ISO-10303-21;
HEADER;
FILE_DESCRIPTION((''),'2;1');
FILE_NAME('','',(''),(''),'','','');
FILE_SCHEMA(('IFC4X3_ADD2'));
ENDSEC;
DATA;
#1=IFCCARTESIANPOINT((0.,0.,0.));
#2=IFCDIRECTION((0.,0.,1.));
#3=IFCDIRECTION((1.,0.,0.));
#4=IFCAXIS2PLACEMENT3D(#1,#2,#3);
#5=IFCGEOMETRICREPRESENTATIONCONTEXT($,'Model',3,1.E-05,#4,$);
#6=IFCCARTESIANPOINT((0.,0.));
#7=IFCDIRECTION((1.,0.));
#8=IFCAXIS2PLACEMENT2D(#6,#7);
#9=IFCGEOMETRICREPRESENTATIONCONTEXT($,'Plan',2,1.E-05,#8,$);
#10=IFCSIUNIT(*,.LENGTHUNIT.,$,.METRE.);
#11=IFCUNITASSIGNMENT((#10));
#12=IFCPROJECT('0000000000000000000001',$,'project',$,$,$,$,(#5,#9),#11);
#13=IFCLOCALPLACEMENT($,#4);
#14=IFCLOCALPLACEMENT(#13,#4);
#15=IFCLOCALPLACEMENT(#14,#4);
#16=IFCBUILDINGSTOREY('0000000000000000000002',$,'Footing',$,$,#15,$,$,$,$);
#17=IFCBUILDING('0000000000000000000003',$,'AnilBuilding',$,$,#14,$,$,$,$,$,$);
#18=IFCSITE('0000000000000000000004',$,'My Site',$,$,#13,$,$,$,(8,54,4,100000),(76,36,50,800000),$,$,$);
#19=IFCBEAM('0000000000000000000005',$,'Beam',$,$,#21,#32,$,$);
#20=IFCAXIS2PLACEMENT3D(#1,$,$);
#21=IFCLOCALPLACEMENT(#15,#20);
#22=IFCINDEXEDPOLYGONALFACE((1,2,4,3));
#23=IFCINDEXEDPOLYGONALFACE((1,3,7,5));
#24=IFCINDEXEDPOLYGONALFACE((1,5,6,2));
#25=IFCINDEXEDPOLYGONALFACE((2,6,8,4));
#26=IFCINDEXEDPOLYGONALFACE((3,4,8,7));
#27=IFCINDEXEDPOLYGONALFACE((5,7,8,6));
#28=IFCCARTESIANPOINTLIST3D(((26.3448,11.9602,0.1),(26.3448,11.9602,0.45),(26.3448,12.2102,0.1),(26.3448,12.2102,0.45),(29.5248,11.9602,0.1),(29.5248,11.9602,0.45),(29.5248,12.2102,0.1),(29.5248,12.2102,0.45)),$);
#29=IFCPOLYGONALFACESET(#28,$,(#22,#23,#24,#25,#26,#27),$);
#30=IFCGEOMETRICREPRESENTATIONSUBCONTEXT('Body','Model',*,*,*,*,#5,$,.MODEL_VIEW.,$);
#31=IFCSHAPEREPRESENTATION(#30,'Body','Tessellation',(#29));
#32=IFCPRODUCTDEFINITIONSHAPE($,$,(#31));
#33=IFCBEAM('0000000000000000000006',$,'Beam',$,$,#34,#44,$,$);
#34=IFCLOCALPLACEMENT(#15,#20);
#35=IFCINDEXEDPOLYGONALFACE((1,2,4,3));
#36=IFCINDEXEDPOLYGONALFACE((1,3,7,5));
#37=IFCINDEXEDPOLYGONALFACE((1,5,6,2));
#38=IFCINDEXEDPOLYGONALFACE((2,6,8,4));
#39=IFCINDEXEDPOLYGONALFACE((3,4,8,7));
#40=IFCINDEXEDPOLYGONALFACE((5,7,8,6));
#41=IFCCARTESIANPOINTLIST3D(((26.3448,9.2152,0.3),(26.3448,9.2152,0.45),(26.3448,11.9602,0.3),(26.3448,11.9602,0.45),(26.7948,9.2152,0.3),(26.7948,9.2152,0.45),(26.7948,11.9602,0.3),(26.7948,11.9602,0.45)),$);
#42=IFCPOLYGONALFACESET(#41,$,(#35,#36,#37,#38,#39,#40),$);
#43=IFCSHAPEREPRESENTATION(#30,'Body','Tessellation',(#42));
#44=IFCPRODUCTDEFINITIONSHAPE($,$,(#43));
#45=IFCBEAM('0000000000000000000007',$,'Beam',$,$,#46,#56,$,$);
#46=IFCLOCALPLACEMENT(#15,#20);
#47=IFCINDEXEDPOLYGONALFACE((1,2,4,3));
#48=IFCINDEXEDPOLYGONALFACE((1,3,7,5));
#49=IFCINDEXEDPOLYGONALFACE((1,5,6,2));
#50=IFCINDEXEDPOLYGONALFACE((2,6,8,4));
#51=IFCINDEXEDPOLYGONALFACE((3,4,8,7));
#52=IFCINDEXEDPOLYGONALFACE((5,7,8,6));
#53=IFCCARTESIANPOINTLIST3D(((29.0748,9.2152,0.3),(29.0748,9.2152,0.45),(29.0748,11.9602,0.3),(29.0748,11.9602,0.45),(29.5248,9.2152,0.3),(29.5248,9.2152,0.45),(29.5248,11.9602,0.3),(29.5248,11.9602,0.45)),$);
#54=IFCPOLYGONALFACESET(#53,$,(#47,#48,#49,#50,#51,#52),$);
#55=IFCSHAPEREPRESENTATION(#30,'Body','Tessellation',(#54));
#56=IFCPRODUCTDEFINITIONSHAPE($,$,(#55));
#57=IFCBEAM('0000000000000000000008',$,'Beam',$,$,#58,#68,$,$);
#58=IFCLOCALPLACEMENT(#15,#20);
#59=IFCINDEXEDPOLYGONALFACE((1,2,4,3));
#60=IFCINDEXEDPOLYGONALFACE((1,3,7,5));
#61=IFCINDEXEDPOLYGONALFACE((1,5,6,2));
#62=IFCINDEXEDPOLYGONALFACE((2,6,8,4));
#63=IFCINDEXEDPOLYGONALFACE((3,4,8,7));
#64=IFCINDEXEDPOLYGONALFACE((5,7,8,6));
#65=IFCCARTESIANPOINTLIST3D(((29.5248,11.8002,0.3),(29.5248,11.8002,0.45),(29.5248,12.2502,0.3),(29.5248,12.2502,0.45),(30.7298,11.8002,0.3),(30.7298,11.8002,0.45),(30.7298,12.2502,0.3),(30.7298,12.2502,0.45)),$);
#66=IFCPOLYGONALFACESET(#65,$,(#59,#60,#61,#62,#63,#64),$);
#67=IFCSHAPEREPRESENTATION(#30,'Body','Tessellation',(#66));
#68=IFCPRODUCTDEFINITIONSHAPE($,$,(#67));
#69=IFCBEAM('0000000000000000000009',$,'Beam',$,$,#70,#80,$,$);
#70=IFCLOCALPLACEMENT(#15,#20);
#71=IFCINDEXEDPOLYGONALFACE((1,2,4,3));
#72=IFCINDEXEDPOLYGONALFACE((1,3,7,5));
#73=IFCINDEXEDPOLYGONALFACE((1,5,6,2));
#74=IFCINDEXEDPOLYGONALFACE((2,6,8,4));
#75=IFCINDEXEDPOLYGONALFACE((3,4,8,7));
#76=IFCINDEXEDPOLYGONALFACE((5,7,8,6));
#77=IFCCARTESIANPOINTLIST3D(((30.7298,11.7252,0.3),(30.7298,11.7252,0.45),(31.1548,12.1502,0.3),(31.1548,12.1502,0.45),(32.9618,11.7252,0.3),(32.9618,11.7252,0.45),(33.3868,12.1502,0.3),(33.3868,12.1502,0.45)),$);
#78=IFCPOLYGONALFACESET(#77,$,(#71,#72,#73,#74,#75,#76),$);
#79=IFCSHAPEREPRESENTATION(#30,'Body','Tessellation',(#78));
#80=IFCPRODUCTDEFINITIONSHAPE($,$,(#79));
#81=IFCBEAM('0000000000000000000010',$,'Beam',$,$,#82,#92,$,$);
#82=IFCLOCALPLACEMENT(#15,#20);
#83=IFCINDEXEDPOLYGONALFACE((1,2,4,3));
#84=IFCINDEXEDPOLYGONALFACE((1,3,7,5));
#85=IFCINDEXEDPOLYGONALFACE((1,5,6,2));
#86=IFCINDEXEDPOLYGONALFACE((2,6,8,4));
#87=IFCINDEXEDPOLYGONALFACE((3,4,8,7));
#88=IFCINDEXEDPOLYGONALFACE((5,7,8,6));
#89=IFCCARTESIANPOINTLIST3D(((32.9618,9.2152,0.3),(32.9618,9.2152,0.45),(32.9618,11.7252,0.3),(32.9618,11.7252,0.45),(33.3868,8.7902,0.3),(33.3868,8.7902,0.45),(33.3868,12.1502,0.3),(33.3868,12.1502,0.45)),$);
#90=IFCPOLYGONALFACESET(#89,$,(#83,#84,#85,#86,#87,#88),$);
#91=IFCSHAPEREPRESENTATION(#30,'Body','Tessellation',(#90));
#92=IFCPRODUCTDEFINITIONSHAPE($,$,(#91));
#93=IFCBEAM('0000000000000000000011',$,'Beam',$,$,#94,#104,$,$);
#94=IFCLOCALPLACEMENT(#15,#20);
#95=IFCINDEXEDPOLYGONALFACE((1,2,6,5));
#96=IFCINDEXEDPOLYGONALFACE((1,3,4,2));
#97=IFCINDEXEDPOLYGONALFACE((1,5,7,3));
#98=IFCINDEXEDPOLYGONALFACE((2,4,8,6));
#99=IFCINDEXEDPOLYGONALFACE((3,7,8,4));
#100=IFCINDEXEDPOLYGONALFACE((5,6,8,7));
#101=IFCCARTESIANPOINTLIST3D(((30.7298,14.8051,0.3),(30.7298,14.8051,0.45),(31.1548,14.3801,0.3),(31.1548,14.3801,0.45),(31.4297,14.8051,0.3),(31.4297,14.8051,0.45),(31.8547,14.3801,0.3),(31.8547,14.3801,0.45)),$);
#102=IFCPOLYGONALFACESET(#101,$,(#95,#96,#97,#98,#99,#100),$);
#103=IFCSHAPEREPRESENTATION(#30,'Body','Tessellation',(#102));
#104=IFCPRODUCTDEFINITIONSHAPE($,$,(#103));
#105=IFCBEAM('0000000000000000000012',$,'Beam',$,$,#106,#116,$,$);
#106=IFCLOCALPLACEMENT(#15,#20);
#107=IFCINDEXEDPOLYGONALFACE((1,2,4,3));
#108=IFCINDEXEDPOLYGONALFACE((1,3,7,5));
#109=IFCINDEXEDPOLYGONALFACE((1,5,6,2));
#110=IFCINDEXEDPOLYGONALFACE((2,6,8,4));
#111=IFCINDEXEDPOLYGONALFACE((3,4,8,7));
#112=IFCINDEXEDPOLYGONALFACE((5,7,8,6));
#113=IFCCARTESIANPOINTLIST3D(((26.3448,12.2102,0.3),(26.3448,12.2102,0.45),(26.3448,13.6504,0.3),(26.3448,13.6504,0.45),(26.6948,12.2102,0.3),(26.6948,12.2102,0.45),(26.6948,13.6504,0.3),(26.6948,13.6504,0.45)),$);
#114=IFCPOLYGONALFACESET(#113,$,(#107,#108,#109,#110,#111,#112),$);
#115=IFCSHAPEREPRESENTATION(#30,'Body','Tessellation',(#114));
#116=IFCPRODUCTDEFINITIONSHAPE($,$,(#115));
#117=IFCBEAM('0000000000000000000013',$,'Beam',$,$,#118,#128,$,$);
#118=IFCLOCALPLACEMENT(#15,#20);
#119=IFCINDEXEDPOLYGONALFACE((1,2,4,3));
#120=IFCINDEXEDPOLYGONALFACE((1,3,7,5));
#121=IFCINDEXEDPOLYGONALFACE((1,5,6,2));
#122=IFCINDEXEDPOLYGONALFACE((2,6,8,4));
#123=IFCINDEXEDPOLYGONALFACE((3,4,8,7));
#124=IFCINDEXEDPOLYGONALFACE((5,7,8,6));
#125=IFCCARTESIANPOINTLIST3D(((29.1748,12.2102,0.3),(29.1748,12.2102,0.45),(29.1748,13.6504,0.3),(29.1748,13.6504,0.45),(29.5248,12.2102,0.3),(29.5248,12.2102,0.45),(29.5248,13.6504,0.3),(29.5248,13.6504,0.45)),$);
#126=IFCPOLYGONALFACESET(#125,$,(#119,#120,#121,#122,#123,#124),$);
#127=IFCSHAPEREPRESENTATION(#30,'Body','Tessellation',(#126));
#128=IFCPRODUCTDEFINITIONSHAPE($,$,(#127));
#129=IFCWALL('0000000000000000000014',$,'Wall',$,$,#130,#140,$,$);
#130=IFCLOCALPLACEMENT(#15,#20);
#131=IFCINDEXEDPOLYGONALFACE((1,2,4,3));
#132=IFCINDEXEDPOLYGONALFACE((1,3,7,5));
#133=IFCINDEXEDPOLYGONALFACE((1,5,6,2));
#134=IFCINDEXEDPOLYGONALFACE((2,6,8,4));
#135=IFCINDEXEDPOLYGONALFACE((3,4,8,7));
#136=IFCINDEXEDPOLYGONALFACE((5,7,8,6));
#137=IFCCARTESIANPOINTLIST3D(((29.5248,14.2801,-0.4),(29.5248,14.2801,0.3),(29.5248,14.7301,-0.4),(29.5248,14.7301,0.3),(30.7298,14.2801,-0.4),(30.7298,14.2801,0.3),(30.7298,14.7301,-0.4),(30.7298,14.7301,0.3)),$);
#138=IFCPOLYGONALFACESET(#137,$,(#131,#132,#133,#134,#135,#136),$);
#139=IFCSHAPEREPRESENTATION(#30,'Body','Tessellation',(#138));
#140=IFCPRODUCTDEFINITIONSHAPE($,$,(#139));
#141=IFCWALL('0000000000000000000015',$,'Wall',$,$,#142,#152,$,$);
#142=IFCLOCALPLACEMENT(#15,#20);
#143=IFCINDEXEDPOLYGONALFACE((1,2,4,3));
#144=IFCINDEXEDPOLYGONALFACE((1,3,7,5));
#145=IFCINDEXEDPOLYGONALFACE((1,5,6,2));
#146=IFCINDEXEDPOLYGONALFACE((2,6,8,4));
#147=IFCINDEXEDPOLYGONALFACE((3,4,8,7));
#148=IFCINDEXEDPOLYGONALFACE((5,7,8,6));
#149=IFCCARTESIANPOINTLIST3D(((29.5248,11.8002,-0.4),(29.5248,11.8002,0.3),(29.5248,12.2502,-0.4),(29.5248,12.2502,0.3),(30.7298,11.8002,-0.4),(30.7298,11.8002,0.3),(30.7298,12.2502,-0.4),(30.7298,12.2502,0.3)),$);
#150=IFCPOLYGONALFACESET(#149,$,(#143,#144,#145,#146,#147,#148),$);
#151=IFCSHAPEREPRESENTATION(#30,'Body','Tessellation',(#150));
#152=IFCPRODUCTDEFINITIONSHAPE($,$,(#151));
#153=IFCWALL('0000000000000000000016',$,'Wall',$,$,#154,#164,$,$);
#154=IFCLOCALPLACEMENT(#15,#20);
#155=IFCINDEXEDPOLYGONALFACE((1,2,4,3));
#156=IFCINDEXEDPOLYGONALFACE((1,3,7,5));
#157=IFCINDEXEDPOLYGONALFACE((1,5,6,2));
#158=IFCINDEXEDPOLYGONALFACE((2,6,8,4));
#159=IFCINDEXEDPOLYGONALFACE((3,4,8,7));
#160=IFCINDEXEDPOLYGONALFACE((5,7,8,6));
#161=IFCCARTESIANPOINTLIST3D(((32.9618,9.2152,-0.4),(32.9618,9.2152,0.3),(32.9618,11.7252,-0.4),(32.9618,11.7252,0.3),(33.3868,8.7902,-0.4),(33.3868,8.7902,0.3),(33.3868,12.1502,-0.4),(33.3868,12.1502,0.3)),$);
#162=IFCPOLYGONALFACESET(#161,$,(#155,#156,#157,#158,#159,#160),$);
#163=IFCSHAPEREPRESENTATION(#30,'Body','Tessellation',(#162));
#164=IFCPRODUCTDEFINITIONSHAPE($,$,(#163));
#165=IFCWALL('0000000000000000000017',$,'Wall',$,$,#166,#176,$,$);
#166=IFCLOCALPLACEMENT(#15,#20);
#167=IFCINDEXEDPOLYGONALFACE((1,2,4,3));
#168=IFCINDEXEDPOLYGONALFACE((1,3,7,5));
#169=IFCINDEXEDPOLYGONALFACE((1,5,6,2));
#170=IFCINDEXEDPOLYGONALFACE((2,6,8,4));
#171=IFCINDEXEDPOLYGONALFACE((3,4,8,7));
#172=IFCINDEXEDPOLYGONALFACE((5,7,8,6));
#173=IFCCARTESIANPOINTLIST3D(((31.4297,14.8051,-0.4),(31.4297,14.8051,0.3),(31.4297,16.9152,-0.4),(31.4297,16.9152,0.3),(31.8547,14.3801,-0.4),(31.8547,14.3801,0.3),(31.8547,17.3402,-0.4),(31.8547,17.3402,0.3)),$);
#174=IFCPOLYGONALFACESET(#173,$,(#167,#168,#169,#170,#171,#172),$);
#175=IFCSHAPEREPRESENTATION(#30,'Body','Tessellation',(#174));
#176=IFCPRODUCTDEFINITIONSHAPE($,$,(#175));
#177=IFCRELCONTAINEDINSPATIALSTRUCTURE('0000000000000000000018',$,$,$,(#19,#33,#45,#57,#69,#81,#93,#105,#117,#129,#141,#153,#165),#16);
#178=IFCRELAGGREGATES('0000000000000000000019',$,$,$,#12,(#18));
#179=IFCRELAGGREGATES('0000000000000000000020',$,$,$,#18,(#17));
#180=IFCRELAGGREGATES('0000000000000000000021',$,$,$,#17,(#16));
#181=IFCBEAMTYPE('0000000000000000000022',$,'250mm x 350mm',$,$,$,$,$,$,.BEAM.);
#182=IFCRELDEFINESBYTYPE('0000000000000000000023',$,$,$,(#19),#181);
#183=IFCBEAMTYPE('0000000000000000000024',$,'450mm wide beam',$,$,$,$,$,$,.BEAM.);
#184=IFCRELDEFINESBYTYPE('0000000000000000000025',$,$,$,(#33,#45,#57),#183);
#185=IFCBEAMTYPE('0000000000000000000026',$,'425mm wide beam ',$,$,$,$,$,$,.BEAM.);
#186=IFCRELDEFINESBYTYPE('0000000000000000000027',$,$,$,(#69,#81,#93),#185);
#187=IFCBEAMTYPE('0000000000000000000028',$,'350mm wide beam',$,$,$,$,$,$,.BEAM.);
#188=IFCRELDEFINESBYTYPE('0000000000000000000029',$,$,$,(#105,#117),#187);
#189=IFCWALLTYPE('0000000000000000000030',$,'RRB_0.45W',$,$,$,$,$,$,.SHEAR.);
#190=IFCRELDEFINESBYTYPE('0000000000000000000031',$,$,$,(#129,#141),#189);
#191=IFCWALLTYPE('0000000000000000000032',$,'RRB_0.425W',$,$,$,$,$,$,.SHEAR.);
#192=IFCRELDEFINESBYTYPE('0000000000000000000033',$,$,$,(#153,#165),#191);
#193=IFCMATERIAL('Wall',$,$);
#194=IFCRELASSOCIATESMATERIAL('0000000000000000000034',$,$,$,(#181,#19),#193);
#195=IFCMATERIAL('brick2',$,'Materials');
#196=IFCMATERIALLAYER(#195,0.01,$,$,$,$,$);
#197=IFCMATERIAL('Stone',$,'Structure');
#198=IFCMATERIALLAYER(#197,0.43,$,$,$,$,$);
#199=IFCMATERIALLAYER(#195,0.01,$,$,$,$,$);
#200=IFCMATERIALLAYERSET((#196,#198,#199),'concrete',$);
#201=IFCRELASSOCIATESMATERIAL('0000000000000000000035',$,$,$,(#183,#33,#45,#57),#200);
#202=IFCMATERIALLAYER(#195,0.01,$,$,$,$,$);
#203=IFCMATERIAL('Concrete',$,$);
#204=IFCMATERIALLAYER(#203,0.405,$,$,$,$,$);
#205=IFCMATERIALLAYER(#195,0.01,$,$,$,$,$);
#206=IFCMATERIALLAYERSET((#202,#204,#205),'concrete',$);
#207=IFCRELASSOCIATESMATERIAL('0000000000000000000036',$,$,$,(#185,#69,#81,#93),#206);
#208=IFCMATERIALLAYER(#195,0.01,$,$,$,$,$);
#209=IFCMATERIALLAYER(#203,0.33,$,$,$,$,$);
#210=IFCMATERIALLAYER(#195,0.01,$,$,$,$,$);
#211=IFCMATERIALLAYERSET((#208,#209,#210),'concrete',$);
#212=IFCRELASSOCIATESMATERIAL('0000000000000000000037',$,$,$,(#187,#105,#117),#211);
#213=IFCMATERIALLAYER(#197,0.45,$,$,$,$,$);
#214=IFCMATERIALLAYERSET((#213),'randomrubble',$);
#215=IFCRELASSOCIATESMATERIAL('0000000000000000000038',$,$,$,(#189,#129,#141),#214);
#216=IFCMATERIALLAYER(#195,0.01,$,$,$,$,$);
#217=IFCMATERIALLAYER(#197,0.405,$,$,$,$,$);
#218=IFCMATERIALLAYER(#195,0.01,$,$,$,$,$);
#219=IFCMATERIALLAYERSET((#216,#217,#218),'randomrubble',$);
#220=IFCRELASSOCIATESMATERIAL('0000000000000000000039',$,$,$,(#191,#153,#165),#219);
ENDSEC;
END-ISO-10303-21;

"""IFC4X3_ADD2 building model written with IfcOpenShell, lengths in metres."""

from ifc_helpers import new_model, si_unit, frame, origin_with_axes, origin_2d_with_axis, place, context, subcontext, project, spatial, line, indexed_curve, rectangle, outline, extrude, material, layer, layer_set, layer_usage, material_profile, profile_set, profile_usage, type_object, element, save


model = new_model("IFC4X3_ADD2")

# Units and contexts
model_context = context("Model", 3, precision=1e-05, world=origin_with_axes())
plan_context = context("Plan", 2, precision=1e-05, world=origin_2d_with_axis())
body_context = subcontext(model_context, "Body", "Model", "MODEL_VIEW")
ifc_project = project(units=[si_unit("LENGTHUNIT", "METRE")], contexts=[model_context, plan_context])

# Site, building, storey
site_placement = place(None, origin_with_axes())
site = spatial("IfcSite", under=ifc_project, at=site_placement, Name="My Site", RefLatitude=(8, 54, 4, 100000), RefLongitude=(76, 36, 50, 800000))
building_placement = place(site_placement, origin_with_axes())
building = spatial("IfcBuilding", under=site, at=building_placement, Name="AnilBuilding")
storey_placement = place(building_placement, origin_with_axes())
storey = spatial("IfcBuildingStorey", under=building, at=storey_placement, Name="Footing")

# Beams
ifc_material_1 = material(Name="Wall")
ifc_material_profile = material_profile(ifc_material_1, rectangle(XDim=0.25, YDim=0.35))
ifc_profile_set = profile_set([ifc_material_profile], Name="concrete")
ifc_profile_usage = profile_usage(ifc_profile_set, cardinal=5)
beam_type_1 = type_object("IfcBeamType", Name="250mm x 350mm", PredefinedType="BEAM", material=ifc_profile_set)
beam_1_placement = place(storey_placement, frame((29.5248, 12.0852, 0.275), z_axis=(-1.0, -0.000001, 0.000001), x_axis=(0.000001, -1.0, 0.0)))
element("IfcBeam", 1, at=beam_1_placement, inside=storey, type_object=beam_type_1, material=ifc_profile_usage, Name="Beam", context=body_context, shape_type="SweptSolid", body=[
    extrude(rectangle(XDim=0.25, YDim=0.35), origin_with_axes(), (0.0, 0.0, 1.0), 3.18),
])
ifc_material_2 = material(Name="brick2", Category="Materials")
ifc_layer_1 = layer(ifc_material_2, 0.01)
ifc_material_3 = material(Name="Stone", Category="Structure")
ifc_layer_2 = layer(ifc_material_3, 0.43)
ifc_layer_3 = layer(ifc_material_2, 0.01)
ifc_layer_set_1 = layer_set([ifc_layer_1, ifc_layer_2, ifc_layer_3], Name="concrete")
ifc_layer_usage_1 = layer_usage(ifc_layer_set_1, "AXIS2", "NEGATIVE", 0.0)
beam_type_2 = type_object("IfcBeamType", Name="450mm wide beam", PredefinedType="BEAM", material=ifc_layer_set_1)
beam_2_placement = place(storey_placement, frame((26.7948, 11.9602, 0.3), z_axis=(0.0, 0.0, 1.0), x_axis=(0.0, -1.0, 0.0)))
element("IfcBeam", 2, at=beam_2_placement, inside=storey, type_object=beam_type_2, material=ifc_layer_usage_1, Name="Beam", context=body_context, shape_type="SweptSolid", body=[
    extrude(outline(indexed_curve([(0.0, -0.45), (0.0, 0.0), (2.745, 0.0), (2.745, -0.45)], segments=[line(1, 2, 3, 4, 1)])), origin_with_axes(), (0.0, 0.0, 1.0), 0.15),
])
ifc_layer_usage_2 = layer_usage(ifc_layer_set_1, "AXIS2", "NEGATIVE", 0.0)
beam_3_placement = place(storey_placement, frame((29.5248, 11.9602, 0.3), z_axis=(0.0, 0.0, 1.0), x_axis=(0.0, -1.0, 0.0)))
element("IfcBeam", 3, at=beam_3_placement, inside=storey, type_object=beam_type_2, material=ifc_layer_usage_2, Name="Beam", context=body_context, shape_type="SweptSolid", body=[
    extrude(outline(indexed_curve([(0.0, -0.45), (0.0, 0.0), (2.745, 0.0), (2.745, -0.45)], segments=[line(1, 2, 3, 4, 1)])), origin_with_axes(), (0.0, 0.0, 1.0), 0.15),
])
ifc_layer_usage_3 = layer_usage(ifc_layer_set_1, "AXIS2", "NEGATIVE", 0.0)
beam_4_placement = place(storey_placement, frame((29.5248, 12.2502, 0.3), z_axis=(0.0, 0.0, 1.0), x_axis=(1.0, 0.0, 0.0)))
element("IfcBeam", 4, at=beam_4_placement, inside=storey, type_object=beam_type_2, material=ifc_layer_usage_3, Name="Beam", context=body_context, shape_type="SweptSolid", body=[
    extrude(outline(indexed_curve([(0.0, -0.45), (0.0, 0.0), (1.205, 0.0), (1.205, -0.45)], segments=[line(1, 2, 3, 4, 1)])), origin_with_axes(), (0.0, 0.0, 1.0), 0.15),
])
ifc_layer_4 = layer(ifc_material_2, 0.01)
ifc_material_4 = material(Name="Concrete")
ifc_layer_5 = layer(ifc_material_4, 0.405)
ifc_layer_6 = layer(ifc_material_2, 0.01)
ifc_layer_set_2 = layer_set([ifc_layer_4, ifc_layer_5, ifc_layer_6], Name="concrete")
ifc_layer_usage_4 = layer_usage(ifc_layer_set_2, "AXIS2", "POSITIVE", 0.0)
beam_type_3 = type_object("IfcBeamType", Name="425mm wide beam ", PredefinedType="BEAM", material=ifc_layer_set_2)
beam_5_placement = place(storey_placement, frame((30.7298, 11.7252, 0.3), z_axis=(0.0, 0.0, 1.0), x_axis=(1.0, 0.0, 0.0)))
element("IfcBeam", 5, at=beam_5_placement, inside=storey, type_object=beam_type_3, material=ifc_layer_usage_4, Name="Beam", context=body_context, shape_type="SweptSolid", body=[
    extrude(outline(indexed_curve([(0.0, 0.0), (0.425, 0.425), (2.657, 0.425), (2.232, 0.0)], segments=[line(1, 2, 3, 4, 1)])), origin_with_axes(), (0.0, 0.0, 1.0), 0.15),
])
ifc_layer_usage_5 = layer_usage(ifc_layer_set_2, "AXIS2", "POSITIVE", 0.0)
beam_6_placement = place(storey_placement, frame((32.9618, 11.7252, 0.3), z_axis=(0.0, 0.0, 1.0), x_axis=(0.0, -1.0, 0.0)))
element("IfcBeam", 6, at=beam_6_placement, inside=storey, type_object=beam_type_3, material=ifc_layer_usage_5, Name="Beam", context=body_context, shape_type="SweptSolid", body=[
    extrude(outline(indexed_curve([(0.0, 0.0), (-0.425, 0.425), (2.935, 0.425), (2.51, 0.0)], segments=[line(1, 2, 3, 4, 1)])), origin_with_axes(), (0.0, 0.0, 1.0), 0.15),
])
ifc_layer_usage_6 = layer_usage(ifc_layer_set_2, "AXIS2", "POSITIVE", 0.0)
beam_7_placement = place(storey_placement, frame((30.7298, 14.3801, 0.3), z_axis=(0.0, 0.0, 1.0), x_axis=(1.0, 0.0, 0.0)))
element("IfcBeam", 7, at=beam_7_placement, inside=storey, type_object=beam_type_3, material=ifc_layer_usage_6, Name="Beam", context=body_context, shape_type="SweptSolid", body=[
    extrude(outline(indexed_curve([(0.425, 0.0), (0.0, 0.425), (0.7, 0.425), (1.125, 0.0)], segments=[line(1, 2, 3, 4, 1)])), origin_with_axes(), (0.0, 0.0, 1.0), 0.15),
])
ifc_layer_7 = layer(ifc_material_2, 0.01)
ifc_layer_8 = layer(ifc_material_4, 0.33)
ifc_layer_9 = layer(ifc_material_2, 0.01)
ifc_layer_set_3 = layer_set([ifc_layer_7, ifc_layer_8, ifc_layer_9], Name="concrete")
ifc_layer_usage_7 = layer_usage(ifc_layer_set_3, "AXIS2", "POSITIVE", 0.0)
beam_type_4 = type_object("IfcBeamType", Name="350mm wide beam", PredefinedType="BEAM", material=ifc_layer_set_3)
beam_8_placement = place(storey_placement, frame((26.3448, 13.6504, 0.3), z_axis=(0.0, 0.0, 1.0), x_axis=(0.0, -1.0, 0.0)))
element("IfcBeam", 8, at=beam_8_placement, inside=storey, type_object=beam_type_4, material=ifc_layer_usage_7, Name="Beam", context=body_context, shape_type="SweptSolid", body=[
    extrude(outline(indexed_curve([(0.0, 0.0), (0.0, 0.35), (1.4402, 0.35), (1.4402, 0.0)], segments=[line(1, 2, 3, 4, 1)])), origin_with_axes(), (0.0, 0.0, 1.0), 0.15),
])
ifc_layer_usage_8 = layer_usage(ifc_layer_set_3, "AXIS2", "POSITIVE", 0.0)
beam_9_placement = place(storey_placement, frame((29.1748, 13.6504, 0.3), z_axis=(0.0, 0.0, 1.0), x_axis=(0.0, -1.0, 0.0)))
element("IfcBeam", 9, at=beam_9_placement, inside=storey, type_object=beam_type_4, material=ifc_layer_usage_8, Name="Beam", context=body_context, shape_type="SweptSolid", body=[
    extrude(outline(indexed_curve([(0.0, 0.0), (0.0, 0.35), (1.4402, 0.35), (1.4402, 0.0)], segments=[line(1, 2, 3, 4, 1)])), origin_with_axes(), (0.0, 0.0, 1.0), 0.15),
])

# Walls
ifc_layer_10 = layer(ifc_material_3, 0.45)
ifc_layer_set_4 = layer_set([ifc_layer_10], Name="randomrubble")
ifc_layer_usage_9 = layer_usage(ifc_layer_set_4, "AXIS2", "POSITIVE", 0.0)
wall_type_1 = type_object("IfcWallType", Name="RRB_0.45W", PredefinedType="SHEAR", material=ifc_layer_set_4)
wall_1_placement = place(storey_placement, frame((29.5248, 14.2801, -0.4), z_axis=(0.0, 0.0, 1.0), x_axis=(1.0, 0.0, 0.0)))
element("IfcWall", 10, at=wall_1_placement, inside=storey, type_object=wall_type_1, material=ifc_layer_usage_9, Name="Wall", context=body_context, shape_type="SweptSolid", body=[
    extrude(outline(indexed_curve([(0.0, 0.0), (0.0, 0.45), (1.205, 0.45), (1.205, 0.0)], segments=[line(1, 2, 3, 4, 1)])), origin_with_axes(), (0.0, 0.0, 1.0), 0.7),
])
ifc_layer_usage_10 = layer_usage(ifc_layer_set_4, "AXIS2", "POSITIVE", 0.0)
wall_2_placement = place(storey_placement, frame((29.5248, 11.8002, -0.4), z_axis=(0.0, 0.0, 1.0), x_axis=(1.0, 0.0, 0.0)))
element("IfcWall", 11, at=wall_2_placement, inside=storey, type_object=wall_type_1, material=ifc_layer_usage_10, Name="Wall", context=body_context, shape_type="SweptSolid", body=[
    extrude(outline(indexed_curve([(0.0, 0.0), (0.0, 0.45), (1.205, 0.45), (1.205, 0.0)], segments=[line(1, 2, 3, 4, 1)])), origin_with_axes(), (0.0, 0.0, 1.0), 0.7),
])
ifc_layer_11 = layer(ifc_material_2, 0.01)
ifc_layer_12 = layer(ifc_material_3, 0.405)
ifc_layer_13 = layer(ifc_material_2, 0.01)
ifc_layer_set_5 = layer_set([ifc_layer_11, ifc_layer_12, ifc_layer_13], Name="randomrubble")
ifc_layer_usage_11 = layer_usage(ifc_layer_set_5, "AXIS2", "POSITIVE", 0.0)
wall_type_2 = type_object("IfcWallType", Name="RRB_0.425W", PredefinedType="SHEAR", material=ifc_layer_set_5)
wall_3_placement = place(storey_placement, frame((33.3868, 8.7902, -0.4), z_axis=(0.0, 0.0, 1.0), x_axis=(0.0, 1.0, 0.0)))
element("IfcWall", 12, at=wall_3_placement, inside=storey, type_object=wall_type_2, material=ifc_layer_usage_11, Name="Wall", context=body_context, shape_type="SweptSolid", body=[
    extrude(outline(indexed_curve([(0.0, 0.0), (0.425, 0.425), (2.935, 0.425), (3.36, 0.0)], segments=[line(1, 2, 3, 4, 1)])), origin_with_axes(), (0.0, 0.0, 1.0), 0.7),
])
ifc_layer_usage_12 = layer_usage(ifc_layer_set_5, "AXIS2", "POSITIVE", 0.0)
wall_4_placement = place(storey_placement, frame((31.8547, 14.3801, -0.4), z_axis=(0.0, 0.0, 1.0), x_axis=(0.0, 1.0, 0.0)))
element("IfcWall", 13, at=wall_4_placement, inside=storey, type_object=wall_type_2, material=ifc_layer_usage_12, Name="Wall", context=body_context, shape_type="SweptSolid", body=[
    extrude(outline(indexed_curve([(0.0, 0.0), (0.425, 0.425), (2.535, 0.425), (2.96, 0.0)], segments=[line(1, 2, 3, 4, 1)])), origin_with_axes(), (0.0, 0.0, 1.0), 0.7),
])

save(model, "model.ifc")
